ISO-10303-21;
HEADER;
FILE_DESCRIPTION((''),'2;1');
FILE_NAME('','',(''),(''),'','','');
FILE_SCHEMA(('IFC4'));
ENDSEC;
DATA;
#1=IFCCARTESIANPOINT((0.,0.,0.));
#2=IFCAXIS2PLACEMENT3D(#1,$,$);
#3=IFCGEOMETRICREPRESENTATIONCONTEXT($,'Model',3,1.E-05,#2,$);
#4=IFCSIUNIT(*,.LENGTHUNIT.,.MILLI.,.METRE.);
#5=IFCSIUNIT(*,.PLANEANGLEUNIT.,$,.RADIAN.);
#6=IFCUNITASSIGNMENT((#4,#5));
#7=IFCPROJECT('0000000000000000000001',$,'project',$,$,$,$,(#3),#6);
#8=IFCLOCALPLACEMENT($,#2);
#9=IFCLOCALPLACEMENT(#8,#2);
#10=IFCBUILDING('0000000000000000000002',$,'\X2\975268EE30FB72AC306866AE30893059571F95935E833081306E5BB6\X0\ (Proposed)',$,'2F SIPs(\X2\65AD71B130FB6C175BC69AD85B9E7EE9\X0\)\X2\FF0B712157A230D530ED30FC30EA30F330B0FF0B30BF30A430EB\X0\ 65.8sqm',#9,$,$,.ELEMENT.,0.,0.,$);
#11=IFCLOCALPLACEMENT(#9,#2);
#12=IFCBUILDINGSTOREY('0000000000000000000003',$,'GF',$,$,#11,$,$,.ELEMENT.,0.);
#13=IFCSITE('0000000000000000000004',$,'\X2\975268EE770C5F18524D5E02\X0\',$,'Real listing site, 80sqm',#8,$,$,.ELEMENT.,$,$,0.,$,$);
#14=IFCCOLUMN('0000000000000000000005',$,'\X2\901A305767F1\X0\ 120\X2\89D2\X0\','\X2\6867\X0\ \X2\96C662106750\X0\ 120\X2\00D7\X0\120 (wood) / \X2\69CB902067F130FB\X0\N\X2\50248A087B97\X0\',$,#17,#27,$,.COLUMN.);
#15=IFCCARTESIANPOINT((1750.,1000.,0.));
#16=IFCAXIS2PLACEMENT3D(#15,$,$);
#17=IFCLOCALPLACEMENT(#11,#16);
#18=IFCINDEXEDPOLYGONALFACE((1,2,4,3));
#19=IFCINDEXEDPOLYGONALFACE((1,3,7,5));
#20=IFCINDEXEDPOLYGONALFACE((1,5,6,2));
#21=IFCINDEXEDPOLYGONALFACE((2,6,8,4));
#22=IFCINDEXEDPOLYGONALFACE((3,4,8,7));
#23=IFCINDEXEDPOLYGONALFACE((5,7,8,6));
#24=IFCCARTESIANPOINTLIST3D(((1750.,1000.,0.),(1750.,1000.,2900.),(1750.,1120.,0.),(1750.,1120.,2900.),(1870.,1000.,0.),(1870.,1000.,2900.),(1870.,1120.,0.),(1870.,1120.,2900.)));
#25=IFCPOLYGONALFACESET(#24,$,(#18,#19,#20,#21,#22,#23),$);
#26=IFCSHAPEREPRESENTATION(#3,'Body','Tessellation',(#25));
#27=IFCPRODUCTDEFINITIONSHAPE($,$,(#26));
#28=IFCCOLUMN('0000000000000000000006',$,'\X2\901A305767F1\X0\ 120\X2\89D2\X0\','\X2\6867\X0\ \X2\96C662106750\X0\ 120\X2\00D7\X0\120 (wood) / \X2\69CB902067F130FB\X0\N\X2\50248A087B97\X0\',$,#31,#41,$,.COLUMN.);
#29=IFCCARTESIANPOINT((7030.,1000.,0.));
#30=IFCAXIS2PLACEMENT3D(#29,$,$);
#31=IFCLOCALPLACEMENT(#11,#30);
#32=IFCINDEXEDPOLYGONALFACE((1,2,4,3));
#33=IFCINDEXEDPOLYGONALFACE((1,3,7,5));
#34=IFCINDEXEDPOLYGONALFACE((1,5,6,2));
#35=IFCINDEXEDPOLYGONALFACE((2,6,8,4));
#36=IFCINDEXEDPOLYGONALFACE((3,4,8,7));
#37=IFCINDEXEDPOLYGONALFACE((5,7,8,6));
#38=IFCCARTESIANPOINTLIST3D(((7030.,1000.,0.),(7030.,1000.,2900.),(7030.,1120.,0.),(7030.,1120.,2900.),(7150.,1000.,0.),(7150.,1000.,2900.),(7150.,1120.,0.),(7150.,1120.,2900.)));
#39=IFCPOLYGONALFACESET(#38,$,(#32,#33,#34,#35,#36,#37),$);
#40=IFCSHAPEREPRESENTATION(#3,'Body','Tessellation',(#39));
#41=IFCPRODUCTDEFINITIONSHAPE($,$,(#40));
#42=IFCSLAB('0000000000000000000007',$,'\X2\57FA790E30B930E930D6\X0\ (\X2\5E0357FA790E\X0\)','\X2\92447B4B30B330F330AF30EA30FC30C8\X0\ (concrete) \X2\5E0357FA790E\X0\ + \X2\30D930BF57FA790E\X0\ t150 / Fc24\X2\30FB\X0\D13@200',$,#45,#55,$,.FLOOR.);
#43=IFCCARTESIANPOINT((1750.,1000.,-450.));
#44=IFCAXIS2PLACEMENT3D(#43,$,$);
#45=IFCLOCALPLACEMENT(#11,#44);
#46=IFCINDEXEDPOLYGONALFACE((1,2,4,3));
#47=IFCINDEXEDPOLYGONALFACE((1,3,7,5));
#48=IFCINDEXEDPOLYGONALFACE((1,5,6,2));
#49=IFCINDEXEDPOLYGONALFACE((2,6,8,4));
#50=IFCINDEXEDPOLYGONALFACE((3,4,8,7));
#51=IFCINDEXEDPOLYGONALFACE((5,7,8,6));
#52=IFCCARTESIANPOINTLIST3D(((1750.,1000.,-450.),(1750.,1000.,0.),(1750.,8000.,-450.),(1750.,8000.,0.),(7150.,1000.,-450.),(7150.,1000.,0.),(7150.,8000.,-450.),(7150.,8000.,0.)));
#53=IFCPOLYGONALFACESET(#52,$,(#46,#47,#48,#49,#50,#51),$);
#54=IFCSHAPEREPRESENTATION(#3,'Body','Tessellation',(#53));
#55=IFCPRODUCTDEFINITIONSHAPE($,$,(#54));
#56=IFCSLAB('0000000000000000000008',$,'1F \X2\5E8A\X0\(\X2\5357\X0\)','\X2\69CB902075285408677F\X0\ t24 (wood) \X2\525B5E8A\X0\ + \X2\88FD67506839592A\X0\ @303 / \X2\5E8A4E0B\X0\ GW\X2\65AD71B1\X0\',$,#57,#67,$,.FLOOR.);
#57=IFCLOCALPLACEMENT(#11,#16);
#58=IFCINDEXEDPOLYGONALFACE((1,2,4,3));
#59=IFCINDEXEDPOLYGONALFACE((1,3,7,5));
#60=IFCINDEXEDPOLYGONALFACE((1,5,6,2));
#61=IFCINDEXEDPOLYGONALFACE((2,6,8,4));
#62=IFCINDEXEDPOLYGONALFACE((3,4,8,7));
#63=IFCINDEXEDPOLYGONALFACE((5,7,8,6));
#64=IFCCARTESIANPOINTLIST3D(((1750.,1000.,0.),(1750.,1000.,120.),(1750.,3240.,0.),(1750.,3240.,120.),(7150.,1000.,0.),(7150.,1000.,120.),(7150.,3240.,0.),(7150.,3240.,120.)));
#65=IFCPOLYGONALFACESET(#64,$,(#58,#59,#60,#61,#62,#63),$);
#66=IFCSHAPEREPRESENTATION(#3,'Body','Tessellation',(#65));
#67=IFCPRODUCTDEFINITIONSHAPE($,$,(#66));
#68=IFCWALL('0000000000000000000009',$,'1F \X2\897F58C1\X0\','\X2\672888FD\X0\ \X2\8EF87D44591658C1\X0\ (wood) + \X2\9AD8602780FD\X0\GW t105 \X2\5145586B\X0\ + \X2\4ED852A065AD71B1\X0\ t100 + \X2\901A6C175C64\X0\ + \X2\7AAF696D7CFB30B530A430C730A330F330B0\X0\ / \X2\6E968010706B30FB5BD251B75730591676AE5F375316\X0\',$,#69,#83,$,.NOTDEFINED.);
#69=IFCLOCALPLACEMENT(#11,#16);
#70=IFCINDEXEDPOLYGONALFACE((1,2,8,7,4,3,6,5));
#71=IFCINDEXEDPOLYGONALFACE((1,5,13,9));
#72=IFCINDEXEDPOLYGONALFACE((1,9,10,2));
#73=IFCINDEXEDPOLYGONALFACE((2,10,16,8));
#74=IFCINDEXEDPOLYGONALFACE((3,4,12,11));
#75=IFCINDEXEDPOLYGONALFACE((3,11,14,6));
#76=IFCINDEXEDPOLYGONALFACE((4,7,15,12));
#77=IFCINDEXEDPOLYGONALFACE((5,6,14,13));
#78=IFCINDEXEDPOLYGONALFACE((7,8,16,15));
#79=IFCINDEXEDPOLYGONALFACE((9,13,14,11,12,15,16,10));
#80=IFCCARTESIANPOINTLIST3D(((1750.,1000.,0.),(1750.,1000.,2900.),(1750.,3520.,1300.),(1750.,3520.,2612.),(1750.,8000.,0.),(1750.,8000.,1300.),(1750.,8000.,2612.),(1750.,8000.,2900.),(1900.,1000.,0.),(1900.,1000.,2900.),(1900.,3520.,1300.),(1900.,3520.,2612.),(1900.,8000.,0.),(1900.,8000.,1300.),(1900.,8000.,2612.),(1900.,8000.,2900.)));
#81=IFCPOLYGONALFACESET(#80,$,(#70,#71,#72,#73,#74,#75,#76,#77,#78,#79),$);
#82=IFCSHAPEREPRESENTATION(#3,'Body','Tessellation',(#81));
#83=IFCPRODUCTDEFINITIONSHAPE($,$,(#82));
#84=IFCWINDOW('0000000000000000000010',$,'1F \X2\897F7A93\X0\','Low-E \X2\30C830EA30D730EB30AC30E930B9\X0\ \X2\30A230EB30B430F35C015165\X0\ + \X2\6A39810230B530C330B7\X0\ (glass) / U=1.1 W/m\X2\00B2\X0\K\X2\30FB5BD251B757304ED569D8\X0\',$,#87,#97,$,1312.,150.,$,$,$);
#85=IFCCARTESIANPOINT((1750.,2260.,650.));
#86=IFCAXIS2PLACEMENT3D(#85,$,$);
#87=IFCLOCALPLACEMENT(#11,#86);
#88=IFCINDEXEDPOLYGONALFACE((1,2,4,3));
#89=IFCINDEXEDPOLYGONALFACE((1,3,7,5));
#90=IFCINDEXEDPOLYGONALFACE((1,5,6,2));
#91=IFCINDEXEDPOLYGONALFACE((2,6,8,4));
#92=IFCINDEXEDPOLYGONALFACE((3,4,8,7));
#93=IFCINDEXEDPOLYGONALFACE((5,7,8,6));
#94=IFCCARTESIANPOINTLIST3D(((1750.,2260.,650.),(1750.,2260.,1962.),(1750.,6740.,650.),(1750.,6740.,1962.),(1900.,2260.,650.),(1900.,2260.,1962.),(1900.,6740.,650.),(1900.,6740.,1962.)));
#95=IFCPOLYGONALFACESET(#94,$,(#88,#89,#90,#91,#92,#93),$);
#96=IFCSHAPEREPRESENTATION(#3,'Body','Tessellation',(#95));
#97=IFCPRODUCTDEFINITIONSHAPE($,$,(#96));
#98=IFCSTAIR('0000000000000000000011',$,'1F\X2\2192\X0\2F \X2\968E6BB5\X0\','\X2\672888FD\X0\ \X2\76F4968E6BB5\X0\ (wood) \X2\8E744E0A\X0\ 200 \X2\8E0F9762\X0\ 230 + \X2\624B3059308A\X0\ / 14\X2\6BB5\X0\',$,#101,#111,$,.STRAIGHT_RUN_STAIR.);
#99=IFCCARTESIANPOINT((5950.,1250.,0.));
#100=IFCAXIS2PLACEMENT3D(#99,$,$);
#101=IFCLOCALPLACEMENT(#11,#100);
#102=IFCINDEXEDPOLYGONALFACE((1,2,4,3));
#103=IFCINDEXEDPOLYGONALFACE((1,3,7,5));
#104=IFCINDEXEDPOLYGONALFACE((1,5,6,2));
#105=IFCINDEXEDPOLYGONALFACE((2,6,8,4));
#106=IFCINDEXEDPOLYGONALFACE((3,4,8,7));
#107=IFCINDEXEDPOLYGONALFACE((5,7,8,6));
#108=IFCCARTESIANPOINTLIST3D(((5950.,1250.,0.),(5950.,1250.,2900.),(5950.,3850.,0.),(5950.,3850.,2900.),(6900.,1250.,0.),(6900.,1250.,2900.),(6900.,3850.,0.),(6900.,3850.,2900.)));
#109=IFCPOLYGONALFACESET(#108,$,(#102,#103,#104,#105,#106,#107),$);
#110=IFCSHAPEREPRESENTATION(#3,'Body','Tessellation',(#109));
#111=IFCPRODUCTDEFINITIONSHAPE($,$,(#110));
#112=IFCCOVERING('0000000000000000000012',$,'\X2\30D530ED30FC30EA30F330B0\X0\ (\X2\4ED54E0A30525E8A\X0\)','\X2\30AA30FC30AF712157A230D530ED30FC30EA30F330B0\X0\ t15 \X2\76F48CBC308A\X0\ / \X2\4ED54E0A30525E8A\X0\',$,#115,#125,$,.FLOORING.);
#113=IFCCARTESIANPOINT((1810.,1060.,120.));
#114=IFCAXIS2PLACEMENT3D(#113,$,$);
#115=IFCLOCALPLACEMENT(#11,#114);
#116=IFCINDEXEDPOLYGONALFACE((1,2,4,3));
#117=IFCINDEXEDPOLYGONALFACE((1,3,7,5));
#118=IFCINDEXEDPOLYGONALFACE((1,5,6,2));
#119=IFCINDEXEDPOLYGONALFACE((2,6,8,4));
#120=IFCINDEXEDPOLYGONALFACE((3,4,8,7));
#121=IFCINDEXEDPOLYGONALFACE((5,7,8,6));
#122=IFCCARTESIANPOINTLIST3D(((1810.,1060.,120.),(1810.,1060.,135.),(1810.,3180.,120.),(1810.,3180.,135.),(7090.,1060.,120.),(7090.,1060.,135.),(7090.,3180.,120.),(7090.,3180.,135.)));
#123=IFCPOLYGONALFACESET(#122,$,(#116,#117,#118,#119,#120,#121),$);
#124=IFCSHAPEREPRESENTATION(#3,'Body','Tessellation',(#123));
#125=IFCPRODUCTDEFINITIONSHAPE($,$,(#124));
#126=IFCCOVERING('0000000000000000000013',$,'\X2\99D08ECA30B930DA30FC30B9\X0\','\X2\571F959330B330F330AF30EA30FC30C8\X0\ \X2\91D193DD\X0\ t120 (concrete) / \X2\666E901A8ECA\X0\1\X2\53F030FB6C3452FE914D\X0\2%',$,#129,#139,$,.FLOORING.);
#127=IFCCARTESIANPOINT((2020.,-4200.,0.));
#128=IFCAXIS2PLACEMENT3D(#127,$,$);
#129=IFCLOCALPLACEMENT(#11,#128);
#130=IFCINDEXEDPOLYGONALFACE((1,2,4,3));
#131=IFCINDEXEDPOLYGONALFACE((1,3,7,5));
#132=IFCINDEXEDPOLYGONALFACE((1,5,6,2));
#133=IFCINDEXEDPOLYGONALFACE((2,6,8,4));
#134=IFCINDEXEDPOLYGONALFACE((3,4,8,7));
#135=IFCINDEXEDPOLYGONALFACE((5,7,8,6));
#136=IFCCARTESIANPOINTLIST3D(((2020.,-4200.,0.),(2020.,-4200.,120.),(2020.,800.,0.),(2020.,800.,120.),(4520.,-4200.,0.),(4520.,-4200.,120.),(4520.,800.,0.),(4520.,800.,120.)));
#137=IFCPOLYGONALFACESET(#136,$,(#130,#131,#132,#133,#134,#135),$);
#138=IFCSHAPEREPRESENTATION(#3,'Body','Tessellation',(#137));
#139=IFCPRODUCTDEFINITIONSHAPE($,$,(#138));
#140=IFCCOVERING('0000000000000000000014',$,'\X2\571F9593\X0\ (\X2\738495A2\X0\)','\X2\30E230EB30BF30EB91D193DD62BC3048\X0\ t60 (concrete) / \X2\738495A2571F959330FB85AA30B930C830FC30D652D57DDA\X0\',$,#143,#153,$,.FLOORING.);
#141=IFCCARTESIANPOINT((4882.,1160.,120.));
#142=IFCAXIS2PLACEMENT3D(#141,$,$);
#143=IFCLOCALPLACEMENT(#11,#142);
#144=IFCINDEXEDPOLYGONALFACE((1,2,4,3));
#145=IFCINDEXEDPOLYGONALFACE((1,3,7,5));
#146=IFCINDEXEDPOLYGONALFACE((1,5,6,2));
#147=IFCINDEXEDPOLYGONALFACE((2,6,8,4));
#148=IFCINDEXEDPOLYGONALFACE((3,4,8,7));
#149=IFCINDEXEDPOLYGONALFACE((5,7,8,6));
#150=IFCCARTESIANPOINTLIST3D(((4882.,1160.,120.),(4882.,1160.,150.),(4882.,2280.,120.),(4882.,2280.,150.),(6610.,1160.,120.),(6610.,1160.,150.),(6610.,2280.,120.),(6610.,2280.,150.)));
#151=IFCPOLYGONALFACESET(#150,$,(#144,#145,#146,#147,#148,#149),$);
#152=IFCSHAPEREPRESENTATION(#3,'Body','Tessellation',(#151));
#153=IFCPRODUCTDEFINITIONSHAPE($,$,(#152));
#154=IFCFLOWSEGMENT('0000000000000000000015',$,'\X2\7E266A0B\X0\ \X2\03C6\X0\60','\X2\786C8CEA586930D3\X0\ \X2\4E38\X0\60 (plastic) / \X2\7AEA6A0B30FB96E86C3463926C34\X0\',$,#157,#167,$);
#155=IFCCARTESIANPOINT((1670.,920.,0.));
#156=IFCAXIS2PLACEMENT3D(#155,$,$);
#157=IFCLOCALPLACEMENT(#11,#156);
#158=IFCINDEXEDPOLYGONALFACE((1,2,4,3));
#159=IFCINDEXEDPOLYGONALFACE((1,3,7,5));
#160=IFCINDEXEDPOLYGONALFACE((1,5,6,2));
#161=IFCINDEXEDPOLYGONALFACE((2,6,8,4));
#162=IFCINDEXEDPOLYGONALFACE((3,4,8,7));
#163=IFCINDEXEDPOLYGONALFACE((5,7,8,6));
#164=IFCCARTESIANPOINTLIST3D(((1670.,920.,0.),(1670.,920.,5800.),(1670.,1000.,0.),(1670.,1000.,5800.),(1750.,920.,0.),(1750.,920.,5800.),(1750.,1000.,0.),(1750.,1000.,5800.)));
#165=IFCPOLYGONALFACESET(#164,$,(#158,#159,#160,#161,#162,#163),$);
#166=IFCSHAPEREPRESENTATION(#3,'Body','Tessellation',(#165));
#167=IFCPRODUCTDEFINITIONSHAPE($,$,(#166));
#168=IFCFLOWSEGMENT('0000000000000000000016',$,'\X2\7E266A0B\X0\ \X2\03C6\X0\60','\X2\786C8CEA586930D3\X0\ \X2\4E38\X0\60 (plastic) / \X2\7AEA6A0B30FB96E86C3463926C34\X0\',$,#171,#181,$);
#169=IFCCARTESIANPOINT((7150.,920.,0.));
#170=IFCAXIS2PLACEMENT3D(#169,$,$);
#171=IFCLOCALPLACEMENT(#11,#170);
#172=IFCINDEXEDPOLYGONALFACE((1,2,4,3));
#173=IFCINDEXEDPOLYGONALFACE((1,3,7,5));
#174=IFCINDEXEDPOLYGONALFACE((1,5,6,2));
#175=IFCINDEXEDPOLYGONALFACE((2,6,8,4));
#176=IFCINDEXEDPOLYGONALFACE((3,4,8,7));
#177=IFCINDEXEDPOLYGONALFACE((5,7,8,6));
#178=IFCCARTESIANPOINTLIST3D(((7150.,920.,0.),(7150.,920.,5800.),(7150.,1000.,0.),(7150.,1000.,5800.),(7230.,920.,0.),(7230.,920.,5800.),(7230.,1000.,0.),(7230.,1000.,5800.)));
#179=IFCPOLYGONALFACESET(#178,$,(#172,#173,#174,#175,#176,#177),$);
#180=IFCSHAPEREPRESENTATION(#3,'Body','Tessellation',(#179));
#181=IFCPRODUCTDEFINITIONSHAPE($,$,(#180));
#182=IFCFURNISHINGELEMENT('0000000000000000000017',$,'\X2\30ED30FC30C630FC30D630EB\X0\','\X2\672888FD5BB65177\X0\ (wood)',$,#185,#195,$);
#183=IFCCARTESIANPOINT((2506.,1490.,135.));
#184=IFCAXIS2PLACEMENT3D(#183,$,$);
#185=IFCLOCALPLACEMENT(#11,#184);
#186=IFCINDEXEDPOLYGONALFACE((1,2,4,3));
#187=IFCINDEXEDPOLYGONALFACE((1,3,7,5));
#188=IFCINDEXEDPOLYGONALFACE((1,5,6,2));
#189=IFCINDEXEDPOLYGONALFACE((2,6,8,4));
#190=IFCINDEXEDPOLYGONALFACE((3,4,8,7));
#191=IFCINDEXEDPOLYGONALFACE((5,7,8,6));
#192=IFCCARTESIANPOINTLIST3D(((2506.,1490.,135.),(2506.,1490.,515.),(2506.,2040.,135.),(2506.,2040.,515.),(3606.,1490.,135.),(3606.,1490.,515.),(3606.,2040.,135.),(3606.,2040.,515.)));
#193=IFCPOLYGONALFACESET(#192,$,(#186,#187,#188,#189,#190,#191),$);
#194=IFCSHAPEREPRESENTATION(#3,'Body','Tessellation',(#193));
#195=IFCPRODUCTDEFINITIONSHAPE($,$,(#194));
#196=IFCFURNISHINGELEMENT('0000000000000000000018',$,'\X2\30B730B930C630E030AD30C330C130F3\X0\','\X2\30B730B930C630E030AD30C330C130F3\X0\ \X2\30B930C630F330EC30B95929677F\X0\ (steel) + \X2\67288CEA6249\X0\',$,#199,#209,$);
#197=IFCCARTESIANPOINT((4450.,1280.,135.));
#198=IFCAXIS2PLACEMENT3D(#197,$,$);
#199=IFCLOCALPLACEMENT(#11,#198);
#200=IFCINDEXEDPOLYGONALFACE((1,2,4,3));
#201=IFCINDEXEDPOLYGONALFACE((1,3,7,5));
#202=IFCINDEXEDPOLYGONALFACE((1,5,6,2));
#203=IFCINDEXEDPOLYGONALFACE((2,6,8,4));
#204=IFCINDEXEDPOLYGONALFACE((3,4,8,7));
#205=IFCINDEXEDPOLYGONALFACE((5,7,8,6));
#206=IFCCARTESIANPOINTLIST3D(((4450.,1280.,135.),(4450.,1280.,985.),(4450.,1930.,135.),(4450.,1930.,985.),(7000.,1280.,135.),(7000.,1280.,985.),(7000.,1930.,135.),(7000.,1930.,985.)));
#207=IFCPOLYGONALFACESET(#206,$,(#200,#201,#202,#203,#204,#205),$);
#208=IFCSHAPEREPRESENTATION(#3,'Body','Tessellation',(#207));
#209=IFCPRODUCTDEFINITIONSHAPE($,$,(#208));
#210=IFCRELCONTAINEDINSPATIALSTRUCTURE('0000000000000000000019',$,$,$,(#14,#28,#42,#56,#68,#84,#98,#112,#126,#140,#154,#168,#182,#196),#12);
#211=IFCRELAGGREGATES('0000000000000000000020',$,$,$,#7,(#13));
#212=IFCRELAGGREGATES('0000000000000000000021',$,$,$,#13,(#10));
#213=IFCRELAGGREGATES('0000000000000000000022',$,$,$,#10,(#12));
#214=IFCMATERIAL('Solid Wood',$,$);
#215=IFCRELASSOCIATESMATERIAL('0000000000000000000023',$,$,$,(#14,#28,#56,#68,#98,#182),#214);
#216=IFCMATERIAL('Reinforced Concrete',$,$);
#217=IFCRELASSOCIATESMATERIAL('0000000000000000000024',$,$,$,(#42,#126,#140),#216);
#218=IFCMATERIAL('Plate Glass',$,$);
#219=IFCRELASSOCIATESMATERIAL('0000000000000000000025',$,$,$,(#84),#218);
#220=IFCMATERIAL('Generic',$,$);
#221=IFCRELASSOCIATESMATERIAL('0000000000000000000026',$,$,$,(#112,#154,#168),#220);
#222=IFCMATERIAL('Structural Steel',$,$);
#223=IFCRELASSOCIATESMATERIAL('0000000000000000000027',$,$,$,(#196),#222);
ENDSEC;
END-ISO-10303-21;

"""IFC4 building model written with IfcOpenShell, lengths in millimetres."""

from ifc_helpers import new_model, si_unit, frame, frame_2d, origin, place, context, project, spatial, rectangle, extrude, material, element, fill, save


model = new_model("IFC4")

# Units and contexts
model_context = context("Model", 3, precision=1e-05, world=origin())
ifc_project = project(units=[si_unit("LENGTHUNIT", "METRE", prefix="MILLI"), si_unit("PLANEANGLEUNIT", "RADIAN")], contexts=[model_context])

# Site, building, storey
site_placement = place(None, origin())
site = spatial("IfcSite", under=ifc_project, at=site_placement, Name="青森県弘前市", ObjectType="Real listing site, 80sqm", CompositionType="ELEMENT", RefElevation=0.0)
building_placement = place(site_placement, origin())
building = spatial("IfcBuilding", under=site, at=building_placement, Name="青森・犬と暮らす土間広めの家 (Proposed)", ObjectType="2F SIPs(断熱・気密高实绩)＋無垢フローリング＋タイル 65.8sqm", CompositionType="ELEMENT", ElevationOfRefHeight=0.0, ElevationOfTerrain=0.0)
storey_placement = place(building_placement, origin())
storey = spatial("IfcBuildingStorey", under=building, at=storey_placement, Name="GF", CompositionType="ELEMENT", Elevation=0.0)

# Columns
ifc_material_1 = material(Name="Solid Wood")
column_1_placement = place(storey_placement, frame((1750.0, 1000.0, 0.0)))
element("IfcColumn", 1, at=column_1_placement, inside=storey, material=ifc_material_1, Name="通し柱 120角", Description="桧 集成材 120×120 (wood) / 構造柱・N値計算", PredefinedType="COLUMN", context=model_context, shape_type="SweptSolid", body=[
    extrude(rectangle(XDim=120.0, YDim=120.0, at=frame_2d((60.0, 60.0))), frame((1750.0, 1000.0, 0.0)), (0.0, 0.0, 1.0), 2900.0),
])
column_2_placement = place(storey_placement, frame((7030.0, 1000.0, 0.0)))
element("IfcColumn", 2, at=column_2_placement, inside=storey, material=ifc_material_1, Name="通し柱 120角", Description="桧 集成材 120×120 (wood) / 構造柱・N値計算", PredefinedType="COLUMN", context=model_context, shape_type="SweptSolid", body=[
    extrude(rectangle(XDim=120.0, YDim=120.0, at=frame_2d((60.0, 60.0))), frame((7030.0, 1000.0, 0.0)), (0.0, 0.0, 1.0), 2900.0),
])

# Slabs
ifc_material_2 = material(Name="Reinforced Concrete")
slab_1_placement = place(storey_placement, frame((1750.0, 1000.0, -450.0)))
element("IfcSlab", 3, at=slab_1_placement, inside=storey, material=ifc_material_2, Name="基礎スラブ (布基礎)", Description="鉄筋コンクリート (concrete) 布基礎 + ベタ基礎 t150 / Fc24・D13@200", PredefinedType="FLOOR", context=model_context, shape_type="SweptSolid", body=[
    extrude(rectangle(XDim=5400.0, YDim=7000.0, at=frame_2d((2700.0, 3500.0))), frame((1750.0, 1000.0, -450.0)), (0.0, 0.0, 1.0), 450.0),
])
slab_2_placement = place(storey_placement, frame((1750.0, 1000.0, 0.0)))
element("IfcSlab", 4, at=slab_2_placement, inside=storey, material=ifc_material_1, Name="1F 床(南)", Description="構造用合板 t24 (wood) 剛床 + 製材根太 @303 / 床下 GW断熱", PredefinedType="FLOOR", context=model_context, shape_type="SweptSolid", body=[
    extrude(rectangle(XDim=5400.0, YDim=2240.0, at=frame_2d((2700.0, 1120.0))), frame((1750.0, 1000.0, 0.0)), (0.0, 0.0, 1.0), 120.0),
])

# Shared definitions
ifc_material_3 = material(Name="Plate Glass")

# Wall, opening, window
wall_1_placement = place(storey_placement, frame((1750.0, 1000.0, 0.0)))
wall_1 = element("IfcWall", 5, at=wall_1_placement, inside=storey, material=ifc_material_1, Name="1F 西壁", Description="木製 軸組外壁 (wood) + 高性能GW t105 充填 + 付加断熱 t100 + 通気層 + 窯業系サイディング / 準耐火・寒冷地外皮強化", PredefinedType="NOTDEFINED", context=model_context, shape_type="SweptSolid", body=[
    extrude(rectangle(XDim=150.0, YDim=7000.0, at=frame_2d((75.0, 3500.0))), frame((1750.0, 1000.0, 0.0)), (0.0, 0.0, 1.0), 2900.0),
])
opening_1_placement = place(storey_placement, frame((1750.0, 2260.0, 650.0)))
opening_1 = element("IfcOpeningElement", 6, at=opening_1_placement, cuts=wall_1, PredefinedType="NOTDEFINED", context=model_context, shape_type="SweptSolid", body=[
    extrude(rectangle(XDim=150.0, YDim=4480.0, at=frame_2d((75.0, 2240.0))), frame((1750.0, 2260.0, 650.0)), (0.0, 0.0, 1.0), 1312.0),
])
window_1_placement = place(storey_placement, frame((1750.0, 2260.0, 650.0)))
window_1 = element("IfcWindow", 7, at=window_1_placement, inside=storey, material=ifc_material_3, Name="1F 西窓", Description="Low-E トリプルガラス アルゴン封入 + 樹脂サッシ (glass) / U=1.1 W/m²K・寒冷地仕様", OverallHeight=1312.0, OverallWidth=150.0, context=model_context, shape_type="SweptSolid", body=[
    extrude(rectangle(XDim=150.0, YDim=4480.0, at=frame_2d((75.0, 2240.0))), frame((1750.0, 2260.0, 650.0)), (0.0, 0.0, 1.0), 1312.0),
])
fill(opening_1, window_1)

# Stair
stair_placement = place(storey_placement, frame((5950.0, 1250.0, 0.0)))
element("IfcStair", 8, at=stair_placement, inside=storey, material=ifc_material_1, Name="1F→2F 階段", Description="木製 直階段 (wood) 蹴上 200 踏面 230 + 手すり / 14段", PredefinedType="STRAIGHT_RUN_STAIR", context=model_context, shape_type="SweptSolid", body=[
    extrude(rectangle(XDim=950.0, YDim=2600.0, at=frame_2d((475.0, 1300.0))), frame((5950.0, 1250.0, 0.0)), (0.0, 0.0, 1.0), 2900.0),
])

# Coverings
ifc_material_4 = material(Name="Generic")
covering_1_placement = place(storey_placement, frame((1810.0, 1060.0, 120.0)))
element("IfcCovering", 9, at=covering_1_placement, inside=storey, material=ifc_material_4, Name="フローリング (仕上げ床)", Description="オーク無垢フローリング t15 直貼り / 仕上げ床", PredefinedType="FLOORING", context=model_context, shape_type="SweptSolid", body=[
    extrude(rectangle(XDim=5280.0, YDim=2120.0, at=frame_2d((2640.0, 1060.0))), frame((1810.0, 1060.0, 120.0)), (0.0, 0.0, 1.0), 15.0),
])
covering_2_placement = place(storey_placement, frame((2020.0, -4200.0, 0.0)))
element("IfcCovering", 10, at=covering_2_placement, inside=storey, material=ifc_material_2, Name="駐車スペース", Description="土間コンクリート 金鏝 t120 (concrete) / 普通車1台・水勾配2%", PredefinedType="FLOORING", context=model_context, shape_type="SweptSolid", body=[
    extrude(rectangle(XDim=2500.0, YDim=5000.0, at=frame_2d((1250.0, 2500.0))), frame((2020.0, -4200.0, 0.0)), (0.0, 0.0, 1.0), 120.0),
])
covering_3_placement = place(storey_placement, frame((4882.0, 1160.0, 120.0)))
element("IfcCovering", 11, at=covering_3_placement, inside=storey, material=ifc_material_2, Name="土間 (玄関)", Description="モルタル金鏝押え t60 (concrete) / 玄関土間・薪ストーブ動線", PredefinedType="FLOORING", context=model_context, shape_type="SweptSolid", body=[
    extrude(rectangle(XDim=1728.0, YDim=1120.0, at=frame_2d((864.0, 560.0))), frame((4882.0, 1160.0, 120.0)), (0.0, 0.0, 1.0), 30.0),
])

# Flow segments
flow_segment_1_placement = place(storey_placement, frame((1670.0, 920.0, 0.0)))
element("IfcFlowSegment", 12, at=flow_segment_1_placement, inside=storey, material=ifc_material_4, Name="縦樋 φ60", Description="硬質塩ビ 丸60 (plastic) / 竪樋・雨水排水", context=model_context, shape_type="SweptSolid", body=[
    extrude(rectangle(XDim=80.0, YDim=80.0, at=frame_2d((40.0, 40.0))), frame((1670.0, 920.0, 0.0)), (0.0, 0.0, 1.0), 5800.0),
])
flow_segment_2_placement = place(storey_placement, frame((7150.0, 920.0, 0.0)))
element("IfcFlowSegment", 13, at=flow_segment_2_placement, inside=storey, material=ifc_material_4, Name="縦樋 φ60", Description="硬質塩ビ 丸60 (plastic) / 竪樋・雨水排水", context=model_context, shape_type="SweptSolid", body=[
    extrude(rectangle(XDim=80.0, YDim=80.0, at=frame_2d((40.0, 40.0))), frame((7150.0, 920.0, 0.0)), (0.0, 0.0, 1.0), 5800.0),
])

# Furnishing elements
furnishing_1_placement = place(storey_placement, frame((2506.0, 1490.0, 135.0)))
element("IfcFurnishingElement", 14, at=furnishing_1_placement, inside=storey, material=ifc_material_1, Name="ローテーブル", Description="木製家具 (wood)", context=model_context, shape_type="SweptSolid", body=[
    extrude(rectangle(XDim=1100.0, YDim=550.0, at=frame_2d((550.0, 275.0))), frame((2506.0, 1490.0, 135.0)), (0.0, 0.0, 1.0), 380.0),
])
ifc_material_5 = material(Name="Structural Steel")
furnishing_2_placement = place(storey_placement, frame((4450.0, 1280.0, 135.0)))
element("IfcFurnishingElement", 15, at=furnishing_2_placement, inside=storey, material=ifc_material_5, Name="システムキッチン", Description="システムキッチン ステンレス天板 (steel) + 木質扉", context=model_context, shape_type="SweptSolid", body=[
    extrude(rectangle(XDim=2550.0, YDim=650.0, at=frame_2d((1275.0, 325.0))), frame((4450.0, 1280.0, 135.0)), (0.0, 0.0, 1.0), 850.0),
])

save(model, "model.ifc")
